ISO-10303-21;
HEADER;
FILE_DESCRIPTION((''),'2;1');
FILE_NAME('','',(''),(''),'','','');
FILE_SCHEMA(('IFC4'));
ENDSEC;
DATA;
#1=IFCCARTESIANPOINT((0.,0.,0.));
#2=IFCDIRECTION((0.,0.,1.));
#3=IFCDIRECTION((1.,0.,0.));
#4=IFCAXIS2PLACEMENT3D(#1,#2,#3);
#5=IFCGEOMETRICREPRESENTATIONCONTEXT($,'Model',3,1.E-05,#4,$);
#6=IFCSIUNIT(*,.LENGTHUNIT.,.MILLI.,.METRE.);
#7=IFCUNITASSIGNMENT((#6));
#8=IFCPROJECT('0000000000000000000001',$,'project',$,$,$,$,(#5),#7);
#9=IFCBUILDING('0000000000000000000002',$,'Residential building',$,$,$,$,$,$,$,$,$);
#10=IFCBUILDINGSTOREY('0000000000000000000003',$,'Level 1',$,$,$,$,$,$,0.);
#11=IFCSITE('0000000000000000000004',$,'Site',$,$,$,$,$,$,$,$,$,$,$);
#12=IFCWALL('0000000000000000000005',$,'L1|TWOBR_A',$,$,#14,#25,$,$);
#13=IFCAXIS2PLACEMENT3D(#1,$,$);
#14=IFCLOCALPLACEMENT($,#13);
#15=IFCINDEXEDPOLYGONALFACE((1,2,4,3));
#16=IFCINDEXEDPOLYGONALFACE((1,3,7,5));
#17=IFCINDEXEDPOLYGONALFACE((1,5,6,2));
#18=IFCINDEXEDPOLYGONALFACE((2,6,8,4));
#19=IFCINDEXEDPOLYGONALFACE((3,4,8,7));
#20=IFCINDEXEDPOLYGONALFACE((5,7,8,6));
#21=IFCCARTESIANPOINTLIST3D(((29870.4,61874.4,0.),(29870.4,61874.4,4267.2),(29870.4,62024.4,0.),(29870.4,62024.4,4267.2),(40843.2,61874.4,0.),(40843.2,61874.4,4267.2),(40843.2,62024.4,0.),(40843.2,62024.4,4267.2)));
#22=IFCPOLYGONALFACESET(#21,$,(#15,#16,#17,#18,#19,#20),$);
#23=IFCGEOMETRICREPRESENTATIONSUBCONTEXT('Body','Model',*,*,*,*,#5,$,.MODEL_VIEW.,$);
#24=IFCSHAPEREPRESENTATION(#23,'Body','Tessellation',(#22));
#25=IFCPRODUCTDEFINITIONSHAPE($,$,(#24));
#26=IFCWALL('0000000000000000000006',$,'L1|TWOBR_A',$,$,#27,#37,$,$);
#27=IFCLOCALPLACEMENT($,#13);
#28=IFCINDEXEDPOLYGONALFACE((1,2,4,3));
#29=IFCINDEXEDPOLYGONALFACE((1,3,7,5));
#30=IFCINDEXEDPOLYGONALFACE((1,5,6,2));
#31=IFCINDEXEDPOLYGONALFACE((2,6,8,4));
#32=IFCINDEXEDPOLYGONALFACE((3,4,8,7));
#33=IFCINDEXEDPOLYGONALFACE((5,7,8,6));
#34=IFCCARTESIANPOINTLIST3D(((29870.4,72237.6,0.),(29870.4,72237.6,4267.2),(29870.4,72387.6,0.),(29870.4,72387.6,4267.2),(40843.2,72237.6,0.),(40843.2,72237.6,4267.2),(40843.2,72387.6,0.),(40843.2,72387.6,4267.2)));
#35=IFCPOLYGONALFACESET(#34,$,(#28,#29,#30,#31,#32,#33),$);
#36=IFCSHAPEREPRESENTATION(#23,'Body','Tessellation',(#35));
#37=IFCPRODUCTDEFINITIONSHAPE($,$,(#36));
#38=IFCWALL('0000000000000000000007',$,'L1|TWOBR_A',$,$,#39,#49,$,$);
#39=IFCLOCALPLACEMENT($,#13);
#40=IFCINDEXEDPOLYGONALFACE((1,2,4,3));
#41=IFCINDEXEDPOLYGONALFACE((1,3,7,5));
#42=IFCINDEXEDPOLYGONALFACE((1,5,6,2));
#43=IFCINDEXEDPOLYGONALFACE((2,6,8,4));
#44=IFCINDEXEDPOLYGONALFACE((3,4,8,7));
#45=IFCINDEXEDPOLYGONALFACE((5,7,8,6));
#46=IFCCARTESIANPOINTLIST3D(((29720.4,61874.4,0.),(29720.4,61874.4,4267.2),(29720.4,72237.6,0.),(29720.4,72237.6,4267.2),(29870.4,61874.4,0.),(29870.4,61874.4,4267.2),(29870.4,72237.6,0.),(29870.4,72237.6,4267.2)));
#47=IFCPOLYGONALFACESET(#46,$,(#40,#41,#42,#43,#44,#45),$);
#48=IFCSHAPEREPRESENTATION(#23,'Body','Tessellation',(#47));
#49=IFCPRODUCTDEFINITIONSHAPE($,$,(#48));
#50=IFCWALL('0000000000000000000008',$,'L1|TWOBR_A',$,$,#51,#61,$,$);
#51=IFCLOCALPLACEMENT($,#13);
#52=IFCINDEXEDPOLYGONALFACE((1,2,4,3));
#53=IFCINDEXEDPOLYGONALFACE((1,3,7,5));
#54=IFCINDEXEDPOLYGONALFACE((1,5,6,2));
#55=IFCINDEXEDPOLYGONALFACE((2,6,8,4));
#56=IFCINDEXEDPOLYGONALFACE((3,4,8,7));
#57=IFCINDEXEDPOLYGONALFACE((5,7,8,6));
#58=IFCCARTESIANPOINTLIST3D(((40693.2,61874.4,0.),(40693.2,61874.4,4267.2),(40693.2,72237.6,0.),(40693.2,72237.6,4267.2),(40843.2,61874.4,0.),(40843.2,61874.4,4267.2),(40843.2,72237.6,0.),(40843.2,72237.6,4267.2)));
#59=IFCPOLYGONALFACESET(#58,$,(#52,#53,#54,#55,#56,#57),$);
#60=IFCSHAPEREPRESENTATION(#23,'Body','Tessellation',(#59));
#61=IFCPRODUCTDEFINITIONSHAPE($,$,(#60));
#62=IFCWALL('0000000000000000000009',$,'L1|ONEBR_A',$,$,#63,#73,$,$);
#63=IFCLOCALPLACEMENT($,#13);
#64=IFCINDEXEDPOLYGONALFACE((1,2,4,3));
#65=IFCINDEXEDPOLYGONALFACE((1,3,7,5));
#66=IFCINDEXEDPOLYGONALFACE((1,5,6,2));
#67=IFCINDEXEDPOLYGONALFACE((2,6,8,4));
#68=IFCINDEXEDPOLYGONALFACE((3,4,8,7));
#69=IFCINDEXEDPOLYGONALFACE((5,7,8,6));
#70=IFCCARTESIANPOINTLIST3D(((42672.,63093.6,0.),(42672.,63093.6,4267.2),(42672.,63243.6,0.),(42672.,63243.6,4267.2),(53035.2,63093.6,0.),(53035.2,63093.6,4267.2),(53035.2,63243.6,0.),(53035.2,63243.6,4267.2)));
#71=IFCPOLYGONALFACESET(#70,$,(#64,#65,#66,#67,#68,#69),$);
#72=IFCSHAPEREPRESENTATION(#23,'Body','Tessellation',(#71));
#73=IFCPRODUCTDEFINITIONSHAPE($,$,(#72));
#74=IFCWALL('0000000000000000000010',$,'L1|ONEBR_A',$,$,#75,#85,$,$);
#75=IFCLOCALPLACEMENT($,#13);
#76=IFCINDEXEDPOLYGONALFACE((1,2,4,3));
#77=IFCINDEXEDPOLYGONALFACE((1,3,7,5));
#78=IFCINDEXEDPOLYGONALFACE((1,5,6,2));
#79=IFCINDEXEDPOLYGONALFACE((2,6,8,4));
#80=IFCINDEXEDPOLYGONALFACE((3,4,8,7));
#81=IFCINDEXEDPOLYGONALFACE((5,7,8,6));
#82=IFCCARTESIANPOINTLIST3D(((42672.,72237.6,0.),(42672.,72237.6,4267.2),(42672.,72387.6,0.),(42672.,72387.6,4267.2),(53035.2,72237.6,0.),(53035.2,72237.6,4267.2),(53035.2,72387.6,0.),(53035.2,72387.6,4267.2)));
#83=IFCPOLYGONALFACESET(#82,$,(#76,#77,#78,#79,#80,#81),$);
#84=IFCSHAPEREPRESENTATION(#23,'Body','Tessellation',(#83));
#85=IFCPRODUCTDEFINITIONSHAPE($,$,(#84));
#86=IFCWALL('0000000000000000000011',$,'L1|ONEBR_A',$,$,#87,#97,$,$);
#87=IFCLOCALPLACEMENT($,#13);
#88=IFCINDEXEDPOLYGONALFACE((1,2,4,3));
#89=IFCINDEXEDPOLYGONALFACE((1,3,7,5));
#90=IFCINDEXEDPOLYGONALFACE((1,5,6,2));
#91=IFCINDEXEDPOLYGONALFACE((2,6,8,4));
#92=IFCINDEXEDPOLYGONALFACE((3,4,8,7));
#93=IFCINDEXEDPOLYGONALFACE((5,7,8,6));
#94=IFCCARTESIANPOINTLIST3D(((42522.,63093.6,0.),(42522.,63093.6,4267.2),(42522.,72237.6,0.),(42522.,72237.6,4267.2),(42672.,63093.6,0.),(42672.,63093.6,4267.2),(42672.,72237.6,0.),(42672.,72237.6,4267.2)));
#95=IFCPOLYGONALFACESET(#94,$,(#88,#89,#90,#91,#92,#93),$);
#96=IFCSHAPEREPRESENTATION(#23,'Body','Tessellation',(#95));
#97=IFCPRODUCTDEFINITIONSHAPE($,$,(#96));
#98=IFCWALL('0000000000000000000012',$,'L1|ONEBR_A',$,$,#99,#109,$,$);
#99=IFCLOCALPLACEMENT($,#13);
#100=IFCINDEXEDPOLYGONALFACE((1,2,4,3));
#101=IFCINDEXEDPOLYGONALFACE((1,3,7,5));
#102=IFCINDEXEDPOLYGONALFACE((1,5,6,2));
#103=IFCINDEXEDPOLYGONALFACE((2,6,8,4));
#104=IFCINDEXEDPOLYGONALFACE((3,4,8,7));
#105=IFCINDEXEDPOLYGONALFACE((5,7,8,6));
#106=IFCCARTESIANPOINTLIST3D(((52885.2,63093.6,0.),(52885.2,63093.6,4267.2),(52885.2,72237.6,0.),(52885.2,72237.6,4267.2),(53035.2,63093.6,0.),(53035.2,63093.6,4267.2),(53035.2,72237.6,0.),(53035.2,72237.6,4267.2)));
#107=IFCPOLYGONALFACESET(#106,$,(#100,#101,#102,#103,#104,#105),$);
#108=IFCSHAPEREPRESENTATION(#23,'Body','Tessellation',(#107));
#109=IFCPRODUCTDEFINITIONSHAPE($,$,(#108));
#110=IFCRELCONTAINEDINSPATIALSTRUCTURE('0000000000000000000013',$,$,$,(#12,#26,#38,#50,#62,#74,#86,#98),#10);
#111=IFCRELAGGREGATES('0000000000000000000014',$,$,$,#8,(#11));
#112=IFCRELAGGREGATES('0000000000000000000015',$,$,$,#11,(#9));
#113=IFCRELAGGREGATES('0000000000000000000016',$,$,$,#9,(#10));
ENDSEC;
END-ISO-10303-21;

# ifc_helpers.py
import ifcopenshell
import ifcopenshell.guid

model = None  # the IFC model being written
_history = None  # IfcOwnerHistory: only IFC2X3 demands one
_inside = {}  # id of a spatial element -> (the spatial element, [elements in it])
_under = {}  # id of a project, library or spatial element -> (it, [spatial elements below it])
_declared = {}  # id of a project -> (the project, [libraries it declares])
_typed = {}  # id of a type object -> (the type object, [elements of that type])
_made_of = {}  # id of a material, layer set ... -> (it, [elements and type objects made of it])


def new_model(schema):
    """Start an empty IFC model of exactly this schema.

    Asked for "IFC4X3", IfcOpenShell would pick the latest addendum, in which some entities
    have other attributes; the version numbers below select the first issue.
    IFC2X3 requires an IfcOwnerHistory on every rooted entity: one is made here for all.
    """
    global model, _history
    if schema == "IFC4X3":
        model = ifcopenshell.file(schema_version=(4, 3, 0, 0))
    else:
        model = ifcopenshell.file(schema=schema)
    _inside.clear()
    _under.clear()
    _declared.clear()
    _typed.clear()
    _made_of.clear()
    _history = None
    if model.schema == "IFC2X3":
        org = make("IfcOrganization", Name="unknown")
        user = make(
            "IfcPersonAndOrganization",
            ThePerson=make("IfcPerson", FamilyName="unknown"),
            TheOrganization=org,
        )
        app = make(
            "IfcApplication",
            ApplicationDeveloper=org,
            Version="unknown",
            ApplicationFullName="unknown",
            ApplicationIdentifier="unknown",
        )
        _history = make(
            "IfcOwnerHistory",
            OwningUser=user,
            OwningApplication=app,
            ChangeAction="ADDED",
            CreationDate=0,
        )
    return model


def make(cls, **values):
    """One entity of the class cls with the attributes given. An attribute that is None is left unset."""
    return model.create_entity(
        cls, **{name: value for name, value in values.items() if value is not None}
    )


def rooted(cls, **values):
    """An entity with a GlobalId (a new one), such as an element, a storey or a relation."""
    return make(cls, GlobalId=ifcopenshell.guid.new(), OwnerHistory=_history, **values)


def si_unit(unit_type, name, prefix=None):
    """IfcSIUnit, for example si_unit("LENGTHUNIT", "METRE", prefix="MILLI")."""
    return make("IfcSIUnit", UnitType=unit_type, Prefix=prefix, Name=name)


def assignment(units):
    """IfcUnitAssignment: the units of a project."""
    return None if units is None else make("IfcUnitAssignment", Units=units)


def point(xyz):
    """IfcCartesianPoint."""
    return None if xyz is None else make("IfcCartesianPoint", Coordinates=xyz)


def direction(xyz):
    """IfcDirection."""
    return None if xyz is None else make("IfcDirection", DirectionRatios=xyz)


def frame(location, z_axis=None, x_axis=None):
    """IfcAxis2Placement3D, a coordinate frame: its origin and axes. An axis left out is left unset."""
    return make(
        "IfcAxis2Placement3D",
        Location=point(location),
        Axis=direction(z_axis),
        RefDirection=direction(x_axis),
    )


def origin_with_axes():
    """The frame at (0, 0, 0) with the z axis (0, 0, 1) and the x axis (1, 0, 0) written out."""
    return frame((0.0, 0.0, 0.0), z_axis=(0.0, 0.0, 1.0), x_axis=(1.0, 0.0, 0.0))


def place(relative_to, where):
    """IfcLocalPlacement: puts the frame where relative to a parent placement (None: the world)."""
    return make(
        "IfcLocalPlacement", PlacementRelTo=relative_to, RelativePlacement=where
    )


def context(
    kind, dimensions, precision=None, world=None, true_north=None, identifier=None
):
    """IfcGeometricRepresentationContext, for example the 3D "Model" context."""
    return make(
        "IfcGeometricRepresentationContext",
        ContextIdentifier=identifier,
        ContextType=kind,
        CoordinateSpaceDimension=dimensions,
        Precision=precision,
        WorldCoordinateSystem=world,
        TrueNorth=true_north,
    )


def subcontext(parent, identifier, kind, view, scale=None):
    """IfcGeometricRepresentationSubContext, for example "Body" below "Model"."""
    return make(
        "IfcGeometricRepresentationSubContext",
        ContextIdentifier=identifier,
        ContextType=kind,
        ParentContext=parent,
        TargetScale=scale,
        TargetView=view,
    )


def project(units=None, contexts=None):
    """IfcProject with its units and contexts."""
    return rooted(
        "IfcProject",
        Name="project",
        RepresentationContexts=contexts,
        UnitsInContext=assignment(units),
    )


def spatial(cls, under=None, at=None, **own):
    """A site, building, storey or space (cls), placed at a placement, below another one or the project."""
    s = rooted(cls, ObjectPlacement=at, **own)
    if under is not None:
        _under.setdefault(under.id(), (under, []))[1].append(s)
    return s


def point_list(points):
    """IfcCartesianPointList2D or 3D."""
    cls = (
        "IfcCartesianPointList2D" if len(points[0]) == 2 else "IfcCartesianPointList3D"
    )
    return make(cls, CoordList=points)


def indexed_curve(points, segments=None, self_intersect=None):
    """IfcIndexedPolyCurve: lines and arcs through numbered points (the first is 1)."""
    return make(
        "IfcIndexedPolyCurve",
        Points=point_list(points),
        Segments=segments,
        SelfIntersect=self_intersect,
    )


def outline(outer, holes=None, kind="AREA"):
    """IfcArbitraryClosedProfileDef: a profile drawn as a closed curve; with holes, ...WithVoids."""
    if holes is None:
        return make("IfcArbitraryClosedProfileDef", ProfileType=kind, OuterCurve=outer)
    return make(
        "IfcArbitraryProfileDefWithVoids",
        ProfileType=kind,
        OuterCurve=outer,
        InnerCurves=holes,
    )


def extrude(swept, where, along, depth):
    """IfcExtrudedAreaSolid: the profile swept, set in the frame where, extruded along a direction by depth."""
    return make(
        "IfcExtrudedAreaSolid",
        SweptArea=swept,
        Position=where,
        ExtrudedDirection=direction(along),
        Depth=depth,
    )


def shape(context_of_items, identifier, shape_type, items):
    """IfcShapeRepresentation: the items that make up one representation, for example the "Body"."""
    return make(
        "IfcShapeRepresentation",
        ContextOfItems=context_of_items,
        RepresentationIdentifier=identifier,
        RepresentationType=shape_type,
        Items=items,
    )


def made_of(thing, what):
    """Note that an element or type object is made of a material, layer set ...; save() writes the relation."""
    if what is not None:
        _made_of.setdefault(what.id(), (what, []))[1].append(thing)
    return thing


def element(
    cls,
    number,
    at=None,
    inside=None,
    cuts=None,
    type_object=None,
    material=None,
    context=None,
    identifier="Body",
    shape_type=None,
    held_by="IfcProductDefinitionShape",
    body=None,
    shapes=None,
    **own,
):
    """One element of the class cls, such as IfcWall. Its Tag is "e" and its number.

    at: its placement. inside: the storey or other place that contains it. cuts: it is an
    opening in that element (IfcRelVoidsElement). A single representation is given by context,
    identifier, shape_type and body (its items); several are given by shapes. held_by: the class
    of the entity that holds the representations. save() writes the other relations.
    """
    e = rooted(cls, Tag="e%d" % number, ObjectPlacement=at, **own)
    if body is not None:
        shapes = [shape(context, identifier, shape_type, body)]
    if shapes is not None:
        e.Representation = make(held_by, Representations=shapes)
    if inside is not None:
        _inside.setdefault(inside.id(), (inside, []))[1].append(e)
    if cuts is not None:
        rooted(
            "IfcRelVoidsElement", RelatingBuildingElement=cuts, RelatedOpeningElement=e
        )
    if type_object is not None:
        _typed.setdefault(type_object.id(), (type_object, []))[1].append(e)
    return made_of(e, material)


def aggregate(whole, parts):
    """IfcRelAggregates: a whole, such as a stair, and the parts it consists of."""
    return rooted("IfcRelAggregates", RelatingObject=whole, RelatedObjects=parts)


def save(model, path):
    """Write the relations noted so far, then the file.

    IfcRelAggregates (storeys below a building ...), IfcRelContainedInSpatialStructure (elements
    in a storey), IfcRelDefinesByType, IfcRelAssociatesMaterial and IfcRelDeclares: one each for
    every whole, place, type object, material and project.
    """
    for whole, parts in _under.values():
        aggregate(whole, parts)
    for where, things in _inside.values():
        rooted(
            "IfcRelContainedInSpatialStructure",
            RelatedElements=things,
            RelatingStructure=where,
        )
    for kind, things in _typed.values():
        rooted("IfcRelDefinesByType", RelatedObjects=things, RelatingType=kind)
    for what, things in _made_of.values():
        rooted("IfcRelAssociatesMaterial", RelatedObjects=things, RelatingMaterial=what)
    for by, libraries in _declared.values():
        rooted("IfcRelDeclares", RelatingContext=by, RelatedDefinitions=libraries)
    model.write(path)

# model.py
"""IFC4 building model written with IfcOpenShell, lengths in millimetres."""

from ifc_helpers import new_model, si_unit, frame, origin_with_axes, place, context, subcontext, project, spatial, indexed_curve, outline, extrude, element, save


model = new_model("IFC4")

# Units and contexts
model_context = context("Model", 3, precision=1e-05, world=origin_with_axes())
body_context = subcontext(model_context, "Body", "Model", "MODEL_VIEW")
ifc_project = project(units=[si_unit("LENGTHUNIT", "METRE", prefix="MILLI")], contexts=[model_context])

# Site, building, storey
site = spatial("IfcSite", under=ifc_project, Name="Site")
building = spatial("IfcBuilding", under=site, Name="Residential building")
storey = spatial("IfcBuildingStorey", under=building, Name="Level 1", Elevation=0.0)

# Walls
for number, where, z_axis, x_axis, name in (
    (1, (29870.4, 61874.4, 0.0), (0.0, 0.0, 1.0), (1.0, 0.0, 0.0), "L1|TWOBR_A"),
    (2, (29870.4, 72237.6, 0.0), (0.0, 0.0, 1.0), (1.0, 0.0, 0.0), "L1|TWOBR_A"),
):
    element("IfcWall", number, at=place(None, frame(where, z_axis=z_axis, x_axis=x_axis)), inside=storey, Name=name, context=body_context, shape_type="SweptSolid", body=[
        extrude(outline(indexed_curve([(0.0, 0.0), (0.0, 150.0), (10972.8, 150.0), (10972.8, 0.0), (0.0, 0.0)], self_intersect=False)), origin_with_axes(), (0.0, 0.0, 1.0), 4267.2),
    ])
for number, where, z_axis, x_axis, name in (
    (3, (29870.4, 61874.4, 0.0), (0.0, 0.0, 1.0), (0.0, 1.0, 0.0), "L1|TWOBR_A"),
    (4, (40843.2, 61874.4, 0.0), (0.0, 0.0, 1.0), (0.0, 1.0, 0.0), "L1|TWOBR_A"),
    (5, (42672.0, 63093.6, 0.0), (0.0, 0.0, 1.0), (1.0, 0.0, 0.0), "L1|ONEBR_A"),
    (6, (42672.0, 72237.6, 0.0), (0.0, 0.0, 1.0), (1.0, 0.0, 0.0), "L1|ONEBR_A"),
):
    element("IfcWall", number, at=place(None, frame(where, z_axis=z_axis, x_axis=x_axis)), inside=storey, Name=name, context=body_context, shape_type="SweptSolid", body=[
        extrude(outline(indexed_curve([(0.0, 0.0), (0.0, 150.0), (10363.2, 150.0), (10363.2, 0.0), (0.0, 0.0)], self_intersect=False)), origin_with_axes(), (0.0, 0.0, 1.0), 4267.2),
    ])
for number, where, z_axis, x_axis, name in (
    (7, (42672.0, 63093.6, 0.0), (0.0, 0.0, 1.0), (0.0, 1.0, 0.0), "L1|ONEBR_A"),
    (8, (53035.2, 63093.6, 0.0), (0.0, 0.0, 1.0), (0.0, 1.0, 0.0), "L1|ONEBR_A"),
):
    element("IfcWall", number, at=place(None, frame(where, z_axis=z_axis, x_axis=x_axis)), inside=storey, Name=name, context=body_context, shape_type="SweptSolid", body=[
        extrude(outline(indexed_curve([(0.0, 0.0), (0.0, 150.0), (9144.0, 150.0), (9144.0, 0.0), (0.0, 0.0)], self_intersect=False)), origin_with_axes(), (0.0, 0.0, 1.0), 4267.2),
    ])

save(model, "model.ifc")
